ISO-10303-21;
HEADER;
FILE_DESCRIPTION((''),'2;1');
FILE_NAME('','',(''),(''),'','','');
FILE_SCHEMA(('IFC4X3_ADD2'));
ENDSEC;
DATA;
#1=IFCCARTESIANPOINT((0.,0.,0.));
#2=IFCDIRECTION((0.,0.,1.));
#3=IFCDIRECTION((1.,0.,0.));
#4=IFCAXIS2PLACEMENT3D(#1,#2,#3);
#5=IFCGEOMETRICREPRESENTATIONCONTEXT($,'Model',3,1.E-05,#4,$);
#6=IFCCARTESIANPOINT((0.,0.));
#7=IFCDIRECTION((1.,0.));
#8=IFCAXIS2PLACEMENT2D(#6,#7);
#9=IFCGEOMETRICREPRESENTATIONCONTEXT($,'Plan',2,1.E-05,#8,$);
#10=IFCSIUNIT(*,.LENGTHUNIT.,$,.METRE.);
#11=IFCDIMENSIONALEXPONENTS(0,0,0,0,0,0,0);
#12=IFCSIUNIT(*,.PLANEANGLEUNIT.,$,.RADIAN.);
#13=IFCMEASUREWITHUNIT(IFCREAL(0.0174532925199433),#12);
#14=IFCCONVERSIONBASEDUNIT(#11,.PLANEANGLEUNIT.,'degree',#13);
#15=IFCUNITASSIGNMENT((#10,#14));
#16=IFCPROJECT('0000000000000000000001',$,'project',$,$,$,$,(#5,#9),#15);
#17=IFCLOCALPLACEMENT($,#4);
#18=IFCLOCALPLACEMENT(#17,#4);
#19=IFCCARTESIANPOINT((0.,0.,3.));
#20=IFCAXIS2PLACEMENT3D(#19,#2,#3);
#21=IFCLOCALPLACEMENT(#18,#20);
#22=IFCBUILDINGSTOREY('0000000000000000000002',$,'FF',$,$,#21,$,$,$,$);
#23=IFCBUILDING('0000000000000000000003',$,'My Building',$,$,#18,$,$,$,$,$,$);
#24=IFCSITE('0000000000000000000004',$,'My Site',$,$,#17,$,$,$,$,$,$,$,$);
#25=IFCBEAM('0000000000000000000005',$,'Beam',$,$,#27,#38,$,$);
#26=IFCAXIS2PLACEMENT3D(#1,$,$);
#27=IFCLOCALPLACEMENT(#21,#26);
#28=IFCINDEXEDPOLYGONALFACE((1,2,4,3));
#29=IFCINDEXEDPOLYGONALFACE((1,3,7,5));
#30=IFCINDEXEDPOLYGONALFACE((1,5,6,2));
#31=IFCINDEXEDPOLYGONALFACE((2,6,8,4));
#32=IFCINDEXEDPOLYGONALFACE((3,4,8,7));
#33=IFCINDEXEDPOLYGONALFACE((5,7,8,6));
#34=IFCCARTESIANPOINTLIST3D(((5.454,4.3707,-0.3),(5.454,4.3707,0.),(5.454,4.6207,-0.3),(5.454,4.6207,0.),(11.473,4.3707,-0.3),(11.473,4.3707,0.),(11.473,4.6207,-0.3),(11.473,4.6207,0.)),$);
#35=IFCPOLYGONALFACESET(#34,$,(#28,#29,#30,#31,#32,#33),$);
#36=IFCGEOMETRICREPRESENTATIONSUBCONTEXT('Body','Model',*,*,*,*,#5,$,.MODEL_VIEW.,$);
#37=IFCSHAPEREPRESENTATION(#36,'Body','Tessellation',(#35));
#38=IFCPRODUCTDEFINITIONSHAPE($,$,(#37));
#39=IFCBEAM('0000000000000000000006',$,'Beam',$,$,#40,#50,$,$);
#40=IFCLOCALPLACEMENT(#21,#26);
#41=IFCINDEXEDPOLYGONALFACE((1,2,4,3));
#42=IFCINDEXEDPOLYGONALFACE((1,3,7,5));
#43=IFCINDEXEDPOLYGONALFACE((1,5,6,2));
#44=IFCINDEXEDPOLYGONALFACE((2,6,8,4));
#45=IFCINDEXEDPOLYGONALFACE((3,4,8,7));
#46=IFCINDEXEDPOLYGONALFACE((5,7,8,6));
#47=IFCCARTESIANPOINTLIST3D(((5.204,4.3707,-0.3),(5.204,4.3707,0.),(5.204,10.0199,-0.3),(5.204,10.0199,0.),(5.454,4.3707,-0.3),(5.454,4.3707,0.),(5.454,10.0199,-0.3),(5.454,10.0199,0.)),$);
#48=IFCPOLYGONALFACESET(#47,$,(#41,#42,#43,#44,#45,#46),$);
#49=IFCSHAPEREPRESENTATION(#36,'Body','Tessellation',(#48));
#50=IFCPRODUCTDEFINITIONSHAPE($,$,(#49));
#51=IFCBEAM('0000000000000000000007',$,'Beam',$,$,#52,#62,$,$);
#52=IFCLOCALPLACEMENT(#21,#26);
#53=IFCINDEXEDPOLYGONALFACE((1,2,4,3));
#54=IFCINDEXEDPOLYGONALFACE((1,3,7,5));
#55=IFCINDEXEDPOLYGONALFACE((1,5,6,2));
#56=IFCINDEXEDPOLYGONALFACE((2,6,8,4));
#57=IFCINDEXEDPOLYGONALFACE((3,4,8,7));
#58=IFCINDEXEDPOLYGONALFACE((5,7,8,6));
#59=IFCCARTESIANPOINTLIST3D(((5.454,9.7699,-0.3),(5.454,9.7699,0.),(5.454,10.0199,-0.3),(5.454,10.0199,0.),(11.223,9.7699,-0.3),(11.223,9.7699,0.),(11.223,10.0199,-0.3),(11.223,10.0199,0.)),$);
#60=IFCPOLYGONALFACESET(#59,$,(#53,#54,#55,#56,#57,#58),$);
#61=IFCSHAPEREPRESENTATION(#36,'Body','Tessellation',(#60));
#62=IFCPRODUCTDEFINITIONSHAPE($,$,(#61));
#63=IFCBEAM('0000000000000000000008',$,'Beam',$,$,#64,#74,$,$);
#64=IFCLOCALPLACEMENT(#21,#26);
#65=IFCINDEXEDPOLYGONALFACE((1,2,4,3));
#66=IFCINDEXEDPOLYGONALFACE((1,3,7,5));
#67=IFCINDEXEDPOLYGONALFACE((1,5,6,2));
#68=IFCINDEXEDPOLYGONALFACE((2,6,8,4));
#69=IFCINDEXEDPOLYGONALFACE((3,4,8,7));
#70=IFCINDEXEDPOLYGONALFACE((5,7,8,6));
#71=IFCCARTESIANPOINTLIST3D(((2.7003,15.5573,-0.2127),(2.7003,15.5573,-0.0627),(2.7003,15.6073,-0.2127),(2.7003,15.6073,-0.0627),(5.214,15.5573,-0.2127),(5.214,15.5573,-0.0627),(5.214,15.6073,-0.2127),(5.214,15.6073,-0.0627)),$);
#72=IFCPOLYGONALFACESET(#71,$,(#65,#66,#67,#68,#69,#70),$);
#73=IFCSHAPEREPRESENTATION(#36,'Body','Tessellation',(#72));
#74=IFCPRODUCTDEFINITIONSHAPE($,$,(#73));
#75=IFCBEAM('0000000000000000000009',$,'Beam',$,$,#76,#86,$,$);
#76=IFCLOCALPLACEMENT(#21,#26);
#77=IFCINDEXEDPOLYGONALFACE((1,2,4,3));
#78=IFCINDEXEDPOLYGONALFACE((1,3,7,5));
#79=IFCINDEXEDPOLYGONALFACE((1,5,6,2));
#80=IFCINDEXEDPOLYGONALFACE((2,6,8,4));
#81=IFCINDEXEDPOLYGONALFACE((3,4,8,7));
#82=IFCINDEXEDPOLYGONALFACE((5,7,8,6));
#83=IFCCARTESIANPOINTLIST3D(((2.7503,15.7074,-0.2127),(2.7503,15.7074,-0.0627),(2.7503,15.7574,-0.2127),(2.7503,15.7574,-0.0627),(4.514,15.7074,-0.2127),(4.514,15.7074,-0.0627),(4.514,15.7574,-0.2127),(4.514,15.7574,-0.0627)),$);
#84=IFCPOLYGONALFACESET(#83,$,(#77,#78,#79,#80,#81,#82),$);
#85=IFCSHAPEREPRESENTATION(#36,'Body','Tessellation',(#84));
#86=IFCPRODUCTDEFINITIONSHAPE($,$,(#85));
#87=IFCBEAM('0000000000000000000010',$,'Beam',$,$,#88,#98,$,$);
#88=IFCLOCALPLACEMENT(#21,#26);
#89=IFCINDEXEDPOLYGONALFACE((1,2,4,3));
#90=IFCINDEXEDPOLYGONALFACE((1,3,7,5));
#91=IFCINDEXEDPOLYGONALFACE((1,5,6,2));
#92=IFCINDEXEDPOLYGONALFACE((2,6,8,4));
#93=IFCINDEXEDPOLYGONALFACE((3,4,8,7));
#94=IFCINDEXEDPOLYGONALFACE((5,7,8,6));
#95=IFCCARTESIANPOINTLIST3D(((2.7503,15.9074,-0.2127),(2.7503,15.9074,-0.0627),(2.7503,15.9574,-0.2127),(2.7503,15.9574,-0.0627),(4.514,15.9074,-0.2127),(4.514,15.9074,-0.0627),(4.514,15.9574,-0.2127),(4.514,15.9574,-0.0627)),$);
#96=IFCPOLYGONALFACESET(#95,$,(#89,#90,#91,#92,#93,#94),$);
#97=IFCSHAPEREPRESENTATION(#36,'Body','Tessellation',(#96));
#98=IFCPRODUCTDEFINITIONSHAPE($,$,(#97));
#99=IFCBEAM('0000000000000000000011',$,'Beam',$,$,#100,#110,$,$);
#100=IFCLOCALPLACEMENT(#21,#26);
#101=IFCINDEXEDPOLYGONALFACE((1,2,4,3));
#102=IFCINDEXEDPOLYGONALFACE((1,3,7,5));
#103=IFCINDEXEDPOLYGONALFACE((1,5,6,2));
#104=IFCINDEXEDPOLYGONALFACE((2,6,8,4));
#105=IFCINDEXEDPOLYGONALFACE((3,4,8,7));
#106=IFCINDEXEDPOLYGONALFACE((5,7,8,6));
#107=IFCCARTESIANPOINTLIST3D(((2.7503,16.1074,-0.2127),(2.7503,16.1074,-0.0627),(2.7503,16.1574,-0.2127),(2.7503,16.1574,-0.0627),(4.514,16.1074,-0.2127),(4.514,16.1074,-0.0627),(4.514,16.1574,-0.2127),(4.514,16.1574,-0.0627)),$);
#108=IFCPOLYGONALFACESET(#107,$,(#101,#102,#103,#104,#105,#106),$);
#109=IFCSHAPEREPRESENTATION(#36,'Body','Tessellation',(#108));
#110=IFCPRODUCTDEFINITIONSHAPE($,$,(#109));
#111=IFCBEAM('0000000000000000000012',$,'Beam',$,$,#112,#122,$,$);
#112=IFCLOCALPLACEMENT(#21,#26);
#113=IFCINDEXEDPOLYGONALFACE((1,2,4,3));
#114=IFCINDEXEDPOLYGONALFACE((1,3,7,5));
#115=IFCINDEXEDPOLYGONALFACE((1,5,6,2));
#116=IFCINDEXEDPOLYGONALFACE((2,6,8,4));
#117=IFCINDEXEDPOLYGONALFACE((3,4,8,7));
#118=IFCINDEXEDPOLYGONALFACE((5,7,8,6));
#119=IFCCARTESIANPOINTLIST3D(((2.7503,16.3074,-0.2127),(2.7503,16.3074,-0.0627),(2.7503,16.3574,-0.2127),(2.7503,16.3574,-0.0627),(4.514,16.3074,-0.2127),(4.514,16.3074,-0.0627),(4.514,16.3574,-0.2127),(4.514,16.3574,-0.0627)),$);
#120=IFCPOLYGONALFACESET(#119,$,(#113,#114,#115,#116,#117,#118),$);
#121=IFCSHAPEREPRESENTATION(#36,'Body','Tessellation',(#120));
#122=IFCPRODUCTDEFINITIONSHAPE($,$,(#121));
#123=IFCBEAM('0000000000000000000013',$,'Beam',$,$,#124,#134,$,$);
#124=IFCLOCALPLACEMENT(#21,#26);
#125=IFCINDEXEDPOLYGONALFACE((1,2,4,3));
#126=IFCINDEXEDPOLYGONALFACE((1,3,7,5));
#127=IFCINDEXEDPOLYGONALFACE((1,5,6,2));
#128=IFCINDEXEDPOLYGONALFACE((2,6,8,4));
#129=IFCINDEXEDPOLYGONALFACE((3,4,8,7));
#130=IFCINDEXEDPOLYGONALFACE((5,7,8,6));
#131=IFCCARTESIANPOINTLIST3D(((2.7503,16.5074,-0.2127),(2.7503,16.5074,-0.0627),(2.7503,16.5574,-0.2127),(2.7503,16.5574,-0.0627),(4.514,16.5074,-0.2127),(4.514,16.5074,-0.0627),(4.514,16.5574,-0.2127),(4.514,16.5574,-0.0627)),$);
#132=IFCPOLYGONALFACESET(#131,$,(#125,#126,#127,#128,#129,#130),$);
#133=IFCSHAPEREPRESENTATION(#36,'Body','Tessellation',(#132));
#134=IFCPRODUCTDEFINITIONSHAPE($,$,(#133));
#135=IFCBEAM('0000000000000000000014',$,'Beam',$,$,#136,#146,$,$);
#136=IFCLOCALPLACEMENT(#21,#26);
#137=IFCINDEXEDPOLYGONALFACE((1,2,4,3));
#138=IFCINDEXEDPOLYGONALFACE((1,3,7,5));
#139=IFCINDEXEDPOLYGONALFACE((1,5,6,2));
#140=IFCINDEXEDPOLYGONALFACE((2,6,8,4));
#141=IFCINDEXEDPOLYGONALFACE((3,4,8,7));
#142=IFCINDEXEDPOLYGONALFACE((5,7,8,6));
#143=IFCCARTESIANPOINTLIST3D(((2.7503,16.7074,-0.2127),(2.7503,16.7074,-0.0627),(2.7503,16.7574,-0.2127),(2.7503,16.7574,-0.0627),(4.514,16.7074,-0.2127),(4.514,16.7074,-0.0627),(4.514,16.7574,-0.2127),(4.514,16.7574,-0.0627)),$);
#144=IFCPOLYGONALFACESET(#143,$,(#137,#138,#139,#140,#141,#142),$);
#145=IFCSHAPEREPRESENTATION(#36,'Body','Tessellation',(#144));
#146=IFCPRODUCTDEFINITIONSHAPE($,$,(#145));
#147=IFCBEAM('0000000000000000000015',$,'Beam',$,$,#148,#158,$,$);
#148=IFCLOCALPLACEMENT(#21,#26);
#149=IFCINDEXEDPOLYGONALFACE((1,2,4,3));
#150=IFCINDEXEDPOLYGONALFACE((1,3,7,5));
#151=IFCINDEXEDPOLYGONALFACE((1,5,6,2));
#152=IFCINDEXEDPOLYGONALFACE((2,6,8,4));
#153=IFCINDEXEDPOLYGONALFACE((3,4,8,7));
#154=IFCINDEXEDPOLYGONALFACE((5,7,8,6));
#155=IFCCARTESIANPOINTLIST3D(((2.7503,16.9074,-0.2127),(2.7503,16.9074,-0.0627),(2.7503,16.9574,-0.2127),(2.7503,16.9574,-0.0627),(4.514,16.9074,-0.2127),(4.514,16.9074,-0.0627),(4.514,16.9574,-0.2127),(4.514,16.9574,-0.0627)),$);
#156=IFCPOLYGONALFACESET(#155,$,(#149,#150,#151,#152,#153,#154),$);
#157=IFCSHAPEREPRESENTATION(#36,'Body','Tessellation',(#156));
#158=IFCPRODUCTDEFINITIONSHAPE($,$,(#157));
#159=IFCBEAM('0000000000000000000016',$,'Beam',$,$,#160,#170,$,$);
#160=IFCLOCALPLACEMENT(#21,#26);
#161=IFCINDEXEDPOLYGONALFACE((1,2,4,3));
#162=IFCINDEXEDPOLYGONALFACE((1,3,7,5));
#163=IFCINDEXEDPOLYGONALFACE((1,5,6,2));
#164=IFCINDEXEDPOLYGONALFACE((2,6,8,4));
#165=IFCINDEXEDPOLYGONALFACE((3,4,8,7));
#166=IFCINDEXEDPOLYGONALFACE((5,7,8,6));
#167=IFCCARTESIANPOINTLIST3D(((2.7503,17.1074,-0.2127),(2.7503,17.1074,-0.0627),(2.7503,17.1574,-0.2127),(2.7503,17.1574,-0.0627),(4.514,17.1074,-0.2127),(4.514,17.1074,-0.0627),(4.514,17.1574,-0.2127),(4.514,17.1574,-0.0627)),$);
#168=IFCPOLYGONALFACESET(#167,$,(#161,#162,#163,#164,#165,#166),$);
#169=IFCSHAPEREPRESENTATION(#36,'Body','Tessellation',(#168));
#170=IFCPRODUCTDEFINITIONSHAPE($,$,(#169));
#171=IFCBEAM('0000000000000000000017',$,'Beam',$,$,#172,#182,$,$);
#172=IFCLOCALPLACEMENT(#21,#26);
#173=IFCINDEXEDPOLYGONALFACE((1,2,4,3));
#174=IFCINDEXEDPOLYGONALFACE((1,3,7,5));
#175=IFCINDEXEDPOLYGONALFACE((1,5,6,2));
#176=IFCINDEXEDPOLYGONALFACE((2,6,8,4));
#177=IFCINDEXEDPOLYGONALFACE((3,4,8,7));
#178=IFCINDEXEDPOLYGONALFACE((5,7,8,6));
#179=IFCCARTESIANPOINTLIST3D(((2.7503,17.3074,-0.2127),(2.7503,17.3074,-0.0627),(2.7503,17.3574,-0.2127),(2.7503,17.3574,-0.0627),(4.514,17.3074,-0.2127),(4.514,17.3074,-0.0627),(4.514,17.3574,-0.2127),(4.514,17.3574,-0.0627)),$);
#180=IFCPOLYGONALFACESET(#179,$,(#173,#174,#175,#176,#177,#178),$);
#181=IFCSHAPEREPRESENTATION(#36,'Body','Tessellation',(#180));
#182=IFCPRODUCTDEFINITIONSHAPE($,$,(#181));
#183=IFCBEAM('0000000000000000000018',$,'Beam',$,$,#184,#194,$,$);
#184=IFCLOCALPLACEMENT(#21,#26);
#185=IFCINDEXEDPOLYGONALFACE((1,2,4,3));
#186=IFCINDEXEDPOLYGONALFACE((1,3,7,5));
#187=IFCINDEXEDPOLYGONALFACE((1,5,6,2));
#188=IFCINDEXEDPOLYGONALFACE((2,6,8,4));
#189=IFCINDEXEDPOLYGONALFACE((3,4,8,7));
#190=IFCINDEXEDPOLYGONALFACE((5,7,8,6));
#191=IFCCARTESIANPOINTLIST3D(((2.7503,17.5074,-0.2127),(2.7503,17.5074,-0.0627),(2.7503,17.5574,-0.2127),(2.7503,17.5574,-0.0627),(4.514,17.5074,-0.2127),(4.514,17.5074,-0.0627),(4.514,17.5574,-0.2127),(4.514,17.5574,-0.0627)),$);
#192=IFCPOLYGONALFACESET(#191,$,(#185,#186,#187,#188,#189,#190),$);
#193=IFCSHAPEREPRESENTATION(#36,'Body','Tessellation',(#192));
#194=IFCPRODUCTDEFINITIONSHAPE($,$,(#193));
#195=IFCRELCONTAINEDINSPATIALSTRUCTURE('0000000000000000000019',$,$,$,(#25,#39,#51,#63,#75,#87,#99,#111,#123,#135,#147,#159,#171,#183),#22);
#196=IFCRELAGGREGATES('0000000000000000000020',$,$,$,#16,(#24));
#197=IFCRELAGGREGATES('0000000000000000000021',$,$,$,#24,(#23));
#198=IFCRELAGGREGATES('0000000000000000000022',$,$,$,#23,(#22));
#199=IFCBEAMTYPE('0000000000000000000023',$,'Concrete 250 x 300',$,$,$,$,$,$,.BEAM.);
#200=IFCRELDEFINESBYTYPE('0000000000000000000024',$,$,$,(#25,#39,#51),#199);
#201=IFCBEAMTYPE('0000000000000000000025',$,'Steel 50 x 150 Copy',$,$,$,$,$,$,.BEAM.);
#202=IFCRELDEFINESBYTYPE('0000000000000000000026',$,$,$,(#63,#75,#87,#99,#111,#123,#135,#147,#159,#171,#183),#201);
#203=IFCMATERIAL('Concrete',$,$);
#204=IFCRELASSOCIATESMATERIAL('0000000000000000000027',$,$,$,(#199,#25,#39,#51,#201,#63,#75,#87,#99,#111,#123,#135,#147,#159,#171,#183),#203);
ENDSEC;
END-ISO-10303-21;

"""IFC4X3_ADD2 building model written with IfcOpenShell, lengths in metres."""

from ifc_helpers import new_model, entity, si_unit, converted_unit, frame, origin_with_axes, origin_2d_with_axis, place, context, subcontext, project, spatial, rectangle, extrude, material, material_profile, profile_set, profile_usage, type_object, element, save


model = new_model("IFC4X3_ADD2")

# Units and contexts
model_context = context("Model", 3, precision=1e-05, world=origin_with_axes())
plan_context = context("Plan", 2, precision=1e-05, world=origin_2d_with_axis())
body_context = subcontext(model_context, "Body", "Model", "MODEL_VIEW")
ifc_project = project(units=[si_unit("LENGTHUNIT", "METRE"), converted_unit("PLANEANGLEUNIT", "degree", entity("IfcReal", 0.0174532925199433), si_unit("PLANEANGLEUNIT", "RADIAN"), dimensions=[0, 0, 0, 0, 0, 0, 0])], contexts=[model_context, plan_context])

# Site, building, storey
site_placement = place(None, origin_with_axes())
site = spatial("IfcSite", under=ifc_project, at=site_placement, Name="My Site")
building_placement = place(site_placement, origin_with_axes())
building = spatial("IfcBuilding", under=site, at=building_placement, Name="My Building")
storey_placement = place(building_placement, frame((0.0, 0.0, 3.0), z_axis=(0.0, 0.0, 1.0), x_axis=(1.0, 0.0, 0.0)))
storey = spatial("IfcBuildingStorey", under=building, at=storey_placement, Name="FF")

# Beams
ifc_material = material(Name="Concrete")
ifc_material_profile_1 = material_profile(ifc_material, rectangle(XDim=0.25, YDim=0.3))
ifc_profile_set_1 = profile_set([ifc_material_profile_1])
ifc_profile_usage_1 = profile_usage(ifc_profile_set_1, cardinal=8)
beam_type_1 = type_object("IfcBeamType", Name="Concrete 250 x 300", PredefinedType="BEAM", material=ifc_profile_set_1)
beam_1_placement = place(storey_placement, frame((5.454, 4.4957, 0.0), z_axis=(1.0, 0.0, 0.0), x_axis=(0.0, 1.0, 0.0)))
element("IfcBeam", 1, at=beam_1_placement, inside=storey, type_object=beam_type_1, material=ifc_profile_usage_1, Name="Beam", context=body_context, shape_type="SweptSolid", body=[
    extrude(rectangle(XDim=0.25, YDim=0.3), frame((0.0, -0.15, 0.0), z_axis=(0.0, 0.0, 1.0), x_axis=(1.0, 0.0, 0.0)), (0.0, 0.0, 1.0), 6.019),
])
ifc_profile_usage_2 = profile_usage(ifc_profile_set_1, cardinal=8)
beam_2_placement = place(storey_placement, frame((5.329, 4.3707, 0.0), z_axis=(0.0, 1.0, 0.0), x_axis=(-1.0, 0.0, 0.0)))
element("IfcBeam", 2, at=beam_2_placement, inside=storey, type_object=beam_type_1, material=ifc_profile_usage_2, Name="Beam", context=body_context, shape_type="SweptSolid", body=[
    extrude(rectangle(XDim=0.25, YDim=0.3), frame((0.0, -0.15, 0.0), z_axis=(0.0, 0.0, 1.0), x_axis=(1.0, 0.0, 0.0)), (0.0, 0.0, 1.0), 5.6492),
])
ifc_profile_usage_3 = profile_usage(ifc_profile_set_1, cardinal=8)
beam_3_placement = place(storey_placement, frame((5.454, 9.8949, 0.0), z_axis=(1.0, 0.0, 0.0), x_axis=(0.0, 1.0, 0.0)))
element("IfcBeam", 3, at=beam_3_placement, inside=storey, type_object=beam_type_1, material=ifc_profile_usage_3, Name="Beam", context=body_context, shape_type="SweptSolid", body=[
    extrude(rectangle(XDim=0.25, YDim=0.3), frame((0.0, -0.15, 0.0), z_axis=(0.0, 0.0, 1.0), x_axis=(1.0, 0.0, 0.0)), (0.0, 0.0, 1.0), 5.769),
])
ifc_material_profile_2 = material_profile(ifc_material, rectangle(XDim=0.05, YDim=0.15))
ifc_profile_set_2 = profile_set([ifc_material_profile_2])
ifc_profile_usage_4 = profile_usage(ifc_profile_set_2)
beam_type_2 = type_object("IfcBeamType", Name="Steel 50 x 150 Copy", PredefinedType="BEAM", material=ifc_profile_set_2)
beam_4_placement = place(storey_placement, frame((2.7003, 15.5823, -0.1377), z_axis=(1.0, 0.0, 0.0), x_axis=(0.0, 1.0, 0.0)))
element("IfcBeam", 4, at=beam_4_placement, inside=storey, type_object=beam_type_2, material=ifc_profile_usage_4, Name="Beam", context=body_context, shape_type="SweptSolid", body=[
    extrude(rectangle(XDim=0.05, YDim=0.15), origin_with_axes(), (0.0, 0.0, 1.0), 2.5138),
])
ifc_profile_usage_5 = profile_usage(ifc_profile_set_2)
beam_5_placement = place(storey_placement, frame((2.7503, 15.7324, -0.1377), z_axis=(1.0, 0.0, 0.0), x_axis=(0.0, 1.0, 0.0)))
element("IfcBeam", 5, at=beam_5_placement, inside=storey, type_object=beam_type_2, material=ifc_profile_usage_5, Name="Beam", context=body_context, shape_type="SweptSolid", body=[
    extrude(rectangle(XDim=0.05, YDim=0.15), origin_with_axes(), (0.0, 0.0, 1.0), 1.7638),
])
ifc_profile_usage_6 = profile_usage(ifc_profile_set_2)
beam_6_placement = place(storey_placement, frame((2.7503, 15.9324, -0.1377), z_axis=(1.0, 0.0, 0.0), x_axis=(0.0, 1.0, 0.0)))
element("IfcBeam", 6, at=beam_6_placement, inside=storey, type_object=beam_type_2, material=ifc_profile_usage_6, Name="Beam", context=body_context, shape_type="SweptSolid", body=[
    extrude(rectangle(XDim=0.05, YDim=0.15), origin_with_axes(), (0.0, 0.0, 1.0), 1.7638),
])
ifc_profile_usage_7 = profile_usage(ifc_profile_set_2)
beam_7_placement = place(storey_placement, frame((2.7503, 16.1324, -0.1377), z_axis=(1.0, 0.0, 0.0), x_axis=(0.0, 1.0, 0.0)))
element("IfcBeam", 7, at=beam_7_placement, inside=storey, type_object=beam_type_2, material=ifc_profile_usage_7, Name="Beam", context=body_context, shape_type="SweptSolid", body=[
    extrude(rectangle(XDim=0.05, YDim=0.15), origin_with_axes(), (0.0, 0.0, 1.0), 1.7638),
])
ifc_profile_usage_8 = profile_usage(ifc_profile_set_2)
beam_8_placement = place(storey_placement, frame((2.7503, 16.3324, -0.1377), z_axis=(1.0, 0.0, 0.0), x_axis=(0.0, 1.0, 0.0)))
element("IfcBeam", 8, at=beam_8_placement, inside=storey, type_object=beam_type_2, material=ifc_profile_usage_8, Name="Beam", context=body_context, shape_type="SweptSolid", body=[
    extrude(rectangle(XDim=0.05, YDim=0.15), origin_with_axes(), (0.0, 0.0, 1.0), 1.7638),
])
ifc_profile_usage_9 = profile_usage(ifc_profile_set_2)
beam_9_placement = place(storey_placement, frame((2.7503, 16.5324, -0.1377), z_axis=(1.0, 0.0, 0.0), x_axis=(0.0, 1.0, 0.0)))
element("IfcBeam", 9, at=beam_9_placement, inside=storey, type_object=beam_type_2, material=ifc_profile_usage_9, Name="Beam", context=body_context, shape_type="SweptSolid", body=[
    extrude(rectangle(XDim=0.05, YDim=0.15), origin_with_axes(), (0.0, 0.0, 1.0), 1.7638),
])
ifc_profile_usage_10 = profile_usage(ifc_profile_set_2)
beam_10_placement = place(storey_placement, frame((2.7503, 16.7324, -0.1377), z_axis=(1.0, 0.0, 0.0), x_axis=(0.0, 1.0, 0.0)))
element("IfcBeam", 10, at=beam_10_placement, inside=storey, type_object=beam_type_2, material=ifc_profile_usage_10, Name="Beam", context=body_context, shape_type="SweptSolid", body=[
    extrude(rectangle(XDim=0.05, YDim=0.15), origin_with_axes(), (0.0, 0.0, 1.0), 1.7638),
])
ifc_profile_usage_11 = profile_usage(ifc_profile_set_2)
beam_11_placement = place(storey_placement, frame((2.7503, 16.9324, -0.1377), z_axis=(1.0, 0.0, 0.0), x_axis=(0.0, 1.0, 0.0)))
element("IfcBeam", 11, at=beam_11_placement, inside=storey, type_object=beam_type_2, material=ifc_profile_usage_11, Name="Beam", context=body_context, shape_type="SweptSolid", body=[
    extrude(rectangle(XDim=0.05, YDim=0.15), origin_with_axes(), (0.0, 0.0, 1.0), 1.7638),
])
ifc_profile_usage_12 = profile_usage(ifc_profile_set_2)
beam_12_placement = place(storey_placement, frame((2.7503, 17.1324, -0.1377), z_axis=(1.0, 0.0, 0.0), x_axis=(0.0, 1.0, 0.0)))
element("IfcBeam", 12, at=beam_12_placement, inside=storey, type_object=beam_type_2, material=ifc_profile_usage_12, Name="Beam", context=body_context, shape_type="SweptSolid", body=[
    extrude(rectangle(XDim=0.05, YDim=0.15), origin_with_axes(), (0.0, 0.0, 1.0), 1.7638),
])
ifc_profile_usage_13 = profile_usage(ifc_profile_set_2)
beam_13_placement = place(storey_placement, frame((2.7503, 17.3324, -0.1377), z_axis=(1.0, 0.0, 0.0), x_axis=(0.0, 1.0, 0.0)))
element("IfcBeam", 13, at=beam_13_placement, inside=storey, type_object=beam_type_2, material=ifc_profile_usage_13, Name="Beam", context=body_context, shape_type="SweptSolid", body=[
    extrude(rectangle(XDim=0.05, YDim=0.15), origin_with_axes(), (0.0, 0.0, 1.0), 1.7638),
])
ifc_profile_usage_14 = profile_usage(ifc_profile_set_2)
beam_14_placement = place(storey_placement, frame((2.7503, 17.5324, -0.1377), z_axis=(1.0, 0.0, 0.0), x_axis=(0.0, 1.0, 0.0)))
element("IfcBeam", 14, at=beam_14_placement, inside=storey, type_object=beam_type_2, material=ifc_profile_usage_14, Name="Beam", context=body_context, shape_type="SweptSolid", body=[
    extrude(rectangle(XDim=0.05, YDim=0.15), origin_with_axes(), (0.0, 0.0, 1.0), 1.7638),
])

save(model, "model.ifc")
